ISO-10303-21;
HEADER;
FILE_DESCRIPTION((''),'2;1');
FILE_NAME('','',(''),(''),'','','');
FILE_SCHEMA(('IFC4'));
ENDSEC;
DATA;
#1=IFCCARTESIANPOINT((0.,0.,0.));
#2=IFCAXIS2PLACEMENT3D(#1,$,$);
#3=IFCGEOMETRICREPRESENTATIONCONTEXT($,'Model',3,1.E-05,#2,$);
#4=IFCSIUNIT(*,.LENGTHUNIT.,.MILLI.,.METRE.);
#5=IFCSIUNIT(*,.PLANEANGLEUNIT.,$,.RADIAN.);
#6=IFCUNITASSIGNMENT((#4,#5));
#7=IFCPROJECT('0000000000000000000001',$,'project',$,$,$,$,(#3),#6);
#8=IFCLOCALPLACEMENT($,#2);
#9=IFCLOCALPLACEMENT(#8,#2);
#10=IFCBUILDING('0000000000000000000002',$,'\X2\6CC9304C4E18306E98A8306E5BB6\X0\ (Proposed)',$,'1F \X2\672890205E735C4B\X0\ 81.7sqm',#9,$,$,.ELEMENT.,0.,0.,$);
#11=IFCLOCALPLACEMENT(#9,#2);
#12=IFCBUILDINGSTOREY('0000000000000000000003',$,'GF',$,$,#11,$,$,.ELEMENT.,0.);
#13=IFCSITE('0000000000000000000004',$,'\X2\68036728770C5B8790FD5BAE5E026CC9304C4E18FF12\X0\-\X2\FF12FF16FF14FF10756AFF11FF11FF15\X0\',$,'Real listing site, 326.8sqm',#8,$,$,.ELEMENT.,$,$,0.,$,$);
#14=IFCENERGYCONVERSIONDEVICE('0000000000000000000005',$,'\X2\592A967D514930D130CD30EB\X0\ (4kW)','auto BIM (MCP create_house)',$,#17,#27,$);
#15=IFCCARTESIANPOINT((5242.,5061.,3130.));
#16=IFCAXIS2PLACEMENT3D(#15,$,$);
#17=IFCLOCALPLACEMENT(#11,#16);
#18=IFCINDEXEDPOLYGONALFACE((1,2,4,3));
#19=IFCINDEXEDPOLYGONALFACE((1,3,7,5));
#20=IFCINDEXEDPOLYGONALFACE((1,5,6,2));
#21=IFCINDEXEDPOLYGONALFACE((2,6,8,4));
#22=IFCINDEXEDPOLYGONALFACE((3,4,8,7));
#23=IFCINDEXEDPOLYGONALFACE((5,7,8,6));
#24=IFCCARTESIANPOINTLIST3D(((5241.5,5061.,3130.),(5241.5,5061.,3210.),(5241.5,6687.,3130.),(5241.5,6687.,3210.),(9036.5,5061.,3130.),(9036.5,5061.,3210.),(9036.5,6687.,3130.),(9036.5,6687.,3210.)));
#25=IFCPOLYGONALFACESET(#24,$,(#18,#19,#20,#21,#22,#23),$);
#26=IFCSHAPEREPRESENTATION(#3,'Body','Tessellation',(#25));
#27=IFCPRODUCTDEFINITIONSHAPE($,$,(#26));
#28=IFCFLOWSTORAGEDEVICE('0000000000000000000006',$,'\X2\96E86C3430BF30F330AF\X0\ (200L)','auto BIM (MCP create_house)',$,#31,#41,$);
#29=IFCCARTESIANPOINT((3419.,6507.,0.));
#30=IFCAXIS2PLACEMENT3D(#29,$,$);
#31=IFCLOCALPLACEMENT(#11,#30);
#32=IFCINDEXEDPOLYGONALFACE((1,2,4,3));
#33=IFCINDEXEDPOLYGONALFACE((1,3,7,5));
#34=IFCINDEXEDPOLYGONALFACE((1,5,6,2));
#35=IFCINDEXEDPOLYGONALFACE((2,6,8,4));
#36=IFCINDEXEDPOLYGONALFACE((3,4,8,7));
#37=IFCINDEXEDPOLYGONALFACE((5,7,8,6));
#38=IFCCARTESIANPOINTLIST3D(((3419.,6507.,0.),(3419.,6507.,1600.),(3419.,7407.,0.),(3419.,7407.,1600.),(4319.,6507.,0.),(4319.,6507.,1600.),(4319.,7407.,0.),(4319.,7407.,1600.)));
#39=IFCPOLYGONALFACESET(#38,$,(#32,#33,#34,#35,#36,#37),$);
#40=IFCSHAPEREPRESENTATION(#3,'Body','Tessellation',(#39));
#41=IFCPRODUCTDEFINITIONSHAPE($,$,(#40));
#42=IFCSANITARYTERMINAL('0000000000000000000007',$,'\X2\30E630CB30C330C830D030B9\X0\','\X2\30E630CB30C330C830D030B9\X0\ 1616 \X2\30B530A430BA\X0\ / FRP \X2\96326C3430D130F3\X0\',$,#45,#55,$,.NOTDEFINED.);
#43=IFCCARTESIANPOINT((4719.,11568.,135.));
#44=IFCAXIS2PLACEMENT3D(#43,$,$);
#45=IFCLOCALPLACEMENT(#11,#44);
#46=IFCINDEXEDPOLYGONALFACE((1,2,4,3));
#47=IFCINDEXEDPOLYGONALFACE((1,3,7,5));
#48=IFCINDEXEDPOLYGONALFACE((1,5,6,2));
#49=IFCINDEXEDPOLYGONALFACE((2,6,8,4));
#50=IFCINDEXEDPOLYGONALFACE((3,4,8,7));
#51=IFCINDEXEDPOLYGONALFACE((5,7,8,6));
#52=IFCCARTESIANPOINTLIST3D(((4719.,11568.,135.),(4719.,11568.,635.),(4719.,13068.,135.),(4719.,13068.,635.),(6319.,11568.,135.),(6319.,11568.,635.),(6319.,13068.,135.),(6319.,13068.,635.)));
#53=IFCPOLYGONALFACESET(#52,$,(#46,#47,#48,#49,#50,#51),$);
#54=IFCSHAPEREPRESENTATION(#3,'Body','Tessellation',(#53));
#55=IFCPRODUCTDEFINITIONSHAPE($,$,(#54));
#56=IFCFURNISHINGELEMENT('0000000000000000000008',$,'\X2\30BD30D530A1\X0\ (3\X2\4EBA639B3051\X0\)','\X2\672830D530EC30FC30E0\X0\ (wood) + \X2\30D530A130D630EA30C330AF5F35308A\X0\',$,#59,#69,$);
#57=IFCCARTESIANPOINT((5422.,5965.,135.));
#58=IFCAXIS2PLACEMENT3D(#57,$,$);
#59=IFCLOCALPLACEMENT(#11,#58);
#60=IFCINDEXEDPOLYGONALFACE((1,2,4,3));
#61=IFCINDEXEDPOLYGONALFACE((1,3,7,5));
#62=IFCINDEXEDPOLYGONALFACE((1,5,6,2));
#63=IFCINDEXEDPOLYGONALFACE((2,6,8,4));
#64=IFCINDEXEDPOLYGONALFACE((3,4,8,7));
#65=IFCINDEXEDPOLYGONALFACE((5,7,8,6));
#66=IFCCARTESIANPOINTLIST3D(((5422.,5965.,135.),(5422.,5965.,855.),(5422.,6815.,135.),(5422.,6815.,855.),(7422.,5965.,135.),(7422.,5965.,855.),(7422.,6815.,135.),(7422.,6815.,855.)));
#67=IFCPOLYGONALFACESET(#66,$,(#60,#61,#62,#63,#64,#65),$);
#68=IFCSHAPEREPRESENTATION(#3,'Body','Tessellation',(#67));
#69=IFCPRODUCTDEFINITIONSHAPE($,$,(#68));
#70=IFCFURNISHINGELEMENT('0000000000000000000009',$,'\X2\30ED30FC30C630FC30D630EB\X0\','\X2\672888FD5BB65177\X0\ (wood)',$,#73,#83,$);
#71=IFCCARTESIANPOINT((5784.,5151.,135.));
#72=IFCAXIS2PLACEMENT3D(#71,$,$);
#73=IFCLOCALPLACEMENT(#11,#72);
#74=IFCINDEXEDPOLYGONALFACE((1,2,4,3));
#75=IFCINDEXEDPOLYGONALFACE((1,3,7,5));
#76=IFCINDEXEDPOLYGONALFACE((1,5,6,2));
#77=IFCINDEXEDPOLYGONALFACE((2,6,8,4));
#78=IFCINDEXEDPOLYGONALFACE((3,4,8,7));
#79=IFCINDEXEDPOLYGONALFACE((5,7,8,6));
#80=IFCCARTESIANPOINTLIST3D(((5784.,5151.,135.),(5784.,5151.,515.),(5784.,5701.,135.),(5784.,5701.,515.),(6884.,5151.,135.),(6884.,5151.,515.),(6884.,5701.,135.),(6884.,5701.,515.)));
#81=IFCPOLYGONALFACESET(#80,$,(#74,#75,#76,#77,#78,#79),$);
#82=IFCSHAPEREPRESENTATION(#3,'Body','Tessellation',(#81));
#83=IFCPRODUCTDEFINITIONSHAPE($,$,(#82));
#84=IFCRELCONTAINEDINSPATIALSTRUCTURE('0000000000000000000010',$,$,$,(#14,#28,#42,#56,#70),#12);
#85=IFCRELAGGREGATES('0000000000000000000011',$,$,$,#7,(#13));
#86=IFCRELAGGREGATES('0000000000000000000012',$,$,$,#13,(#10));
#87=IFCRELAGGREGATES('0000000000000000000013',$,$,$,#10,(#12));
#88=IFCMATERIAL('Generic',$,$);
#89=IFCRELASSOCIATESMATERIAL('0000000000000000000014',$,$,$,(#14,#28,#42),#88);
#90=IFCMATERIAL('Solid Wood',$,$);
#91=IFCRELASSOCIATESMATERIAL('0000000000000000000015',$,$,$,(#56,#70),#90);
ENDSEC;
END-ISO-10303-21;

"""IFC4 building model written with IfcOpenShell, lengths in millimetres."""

from ifc_helpers import new_model, si_unit, frame, frame_2d, origin, place, context, project, spatial, rectangle, extrude, material, element, save


model = new_model("IFC4")

# Units and contexts
model_context = context("Model", 3, precision=1e-05, world=origin())
ifc_project = project(units=[si_unit("LENGTHUNIT", "METRE", prefix="MILLI"), si_unit("PLANEANGLEUNIT", "RADIAN")], contexts=[model_context])

# Site, building, storey
site_placement = place(None, origin())
site = spatial("IfcSite", under=ifc_project, at=site_placement, Name="栃木県宇都宮市泉が丘２-２６４０番１１５", ObjectType="Real listing site, 326.8sqm", CompositionType="ELEMENT", RefElevation=0.0)
building_placement = place(site_placement, origin())
building = spatial("IfcBuilding", under=site, at=building_placement, Name="泉が丘の風の家 (Proposed)", ObjectType="1F 木造平屋 81.7sqm", CompositionType="ELEMENT", ElevationOfRefHeight=0.0, ElevationOfTerrain=0.0)
storey_placement = place(building_placement, origin())
storey = spatial("IfcBuildingStorey", under=building, at=storey_placement, Name="GF", CompositionType="ELEMENT", Elevation=0.0)

# Shared definitions
ifc_material_1 = material(Name="Solid Wood")

# Shared definitions
ifc_material_2 = material(Name="Generic")

# Energy conversion device
energy_conversion_device_placement = place(storey_placement, frame((5242.0, 5061.0, 3130.0)))
element("IfcEnergyConversionDevice", 1, at=energy_conversion_device_placement, inside=storey, material=ifc_material_2, Name="太陽光パネル (4kW)", Description="auto BIM (MCP create_house)", context=model_context, shape_type="SweptSolid", body=[
    extrude(rectangle(XDim=3795.0, YDim=1626.0, at=frame_2d((1897.0, 813.0))), frame((5242.0, 5061.0, 3130.0)), (0.0, 0.0, 1.0), 80.0),
])

# Flow storage device
flow_storage_device_placement = place(storey_placement, frame((3419.0, 6507.0, 0.0)))
element("IfcFlowStorageDevice", 2, at=flow_storage_device_placement, inside=storey, material=ifc_material_2, Name="雨水タンク (200L)", Description="auto BIM (MCP create_house)", context=model_context, shape_type="SweptSolid", body=[
    extrude(rectangle(XDim=900.0, YDim=900.0, at=frame_2d((450.0, 450.0))), frame((3419.0, 6507.0, 0.0)), (0.0, 0.0, 1.0), 1600.0),
])

# Sanitary terminal
sanitary_terminal_placement = place(storey_placement, frame((4719.0, 11568.0, 135.0)))
element("IfcSanitaryTerminal", 3, at=sanitary_terminal_placement, inside=storey, material=ifc_material_2, Name="ユニットバス", Description="ユニットバス 1616 サイズ / FRP 防水パン", PredefinedType="NOTDEFINED", context=model_context, shape_type="SweptSolid", body=[
    extrude(rectangle(XDim=1600.0, YDim=1500.0, at=frame_2d((800.0, 750.0))), frame((4719.0, 11568.0, 135.0)), (0.0, 0.0, 1.0), 500.0),
])

# Furnishing elements
furnishing_1_placement = place(storey_placement, frame((5422.0, 5965.0, 135.0)))
element("IfcFurnishingElement", 4, at=furnishing_1_placement, inside=storey, material=ifc_material_1, Name="ソファ (3人掛け)", Description="木フレーム (wood) + ファブリック張り", context=model_context, shape_type="SweptSolid", body=[
    extrude(rectangle(XDim=2000.0, YDim=850.0, at=frame_2d((1000.0, 425.0))), frame((5422.0, 5965.0, 135.0)), (0.0, 0.0, 1.0), 720.0),
])
furnishing_2_placement = place(storey_placement, frame((5784.0, 5151.0, 135.0)))
element("IfcFurnishingElement", 5, at=furnishing_2_placement, inside=storey, material=ifc_material_1, Name="ローテーブル", Description="木製家具 (wood)", context=model_context, shape_type="SweptSolid", body=[
    extrude(rectangle(XDim=1100.0, YDim=550.0, at=frame_2d((550.0, 275.0))), frame((5784.0, 5151.0, 135.0)), (0.0, 0.0, 1.0), 380.0),
])

save(model, "model.ifc")
